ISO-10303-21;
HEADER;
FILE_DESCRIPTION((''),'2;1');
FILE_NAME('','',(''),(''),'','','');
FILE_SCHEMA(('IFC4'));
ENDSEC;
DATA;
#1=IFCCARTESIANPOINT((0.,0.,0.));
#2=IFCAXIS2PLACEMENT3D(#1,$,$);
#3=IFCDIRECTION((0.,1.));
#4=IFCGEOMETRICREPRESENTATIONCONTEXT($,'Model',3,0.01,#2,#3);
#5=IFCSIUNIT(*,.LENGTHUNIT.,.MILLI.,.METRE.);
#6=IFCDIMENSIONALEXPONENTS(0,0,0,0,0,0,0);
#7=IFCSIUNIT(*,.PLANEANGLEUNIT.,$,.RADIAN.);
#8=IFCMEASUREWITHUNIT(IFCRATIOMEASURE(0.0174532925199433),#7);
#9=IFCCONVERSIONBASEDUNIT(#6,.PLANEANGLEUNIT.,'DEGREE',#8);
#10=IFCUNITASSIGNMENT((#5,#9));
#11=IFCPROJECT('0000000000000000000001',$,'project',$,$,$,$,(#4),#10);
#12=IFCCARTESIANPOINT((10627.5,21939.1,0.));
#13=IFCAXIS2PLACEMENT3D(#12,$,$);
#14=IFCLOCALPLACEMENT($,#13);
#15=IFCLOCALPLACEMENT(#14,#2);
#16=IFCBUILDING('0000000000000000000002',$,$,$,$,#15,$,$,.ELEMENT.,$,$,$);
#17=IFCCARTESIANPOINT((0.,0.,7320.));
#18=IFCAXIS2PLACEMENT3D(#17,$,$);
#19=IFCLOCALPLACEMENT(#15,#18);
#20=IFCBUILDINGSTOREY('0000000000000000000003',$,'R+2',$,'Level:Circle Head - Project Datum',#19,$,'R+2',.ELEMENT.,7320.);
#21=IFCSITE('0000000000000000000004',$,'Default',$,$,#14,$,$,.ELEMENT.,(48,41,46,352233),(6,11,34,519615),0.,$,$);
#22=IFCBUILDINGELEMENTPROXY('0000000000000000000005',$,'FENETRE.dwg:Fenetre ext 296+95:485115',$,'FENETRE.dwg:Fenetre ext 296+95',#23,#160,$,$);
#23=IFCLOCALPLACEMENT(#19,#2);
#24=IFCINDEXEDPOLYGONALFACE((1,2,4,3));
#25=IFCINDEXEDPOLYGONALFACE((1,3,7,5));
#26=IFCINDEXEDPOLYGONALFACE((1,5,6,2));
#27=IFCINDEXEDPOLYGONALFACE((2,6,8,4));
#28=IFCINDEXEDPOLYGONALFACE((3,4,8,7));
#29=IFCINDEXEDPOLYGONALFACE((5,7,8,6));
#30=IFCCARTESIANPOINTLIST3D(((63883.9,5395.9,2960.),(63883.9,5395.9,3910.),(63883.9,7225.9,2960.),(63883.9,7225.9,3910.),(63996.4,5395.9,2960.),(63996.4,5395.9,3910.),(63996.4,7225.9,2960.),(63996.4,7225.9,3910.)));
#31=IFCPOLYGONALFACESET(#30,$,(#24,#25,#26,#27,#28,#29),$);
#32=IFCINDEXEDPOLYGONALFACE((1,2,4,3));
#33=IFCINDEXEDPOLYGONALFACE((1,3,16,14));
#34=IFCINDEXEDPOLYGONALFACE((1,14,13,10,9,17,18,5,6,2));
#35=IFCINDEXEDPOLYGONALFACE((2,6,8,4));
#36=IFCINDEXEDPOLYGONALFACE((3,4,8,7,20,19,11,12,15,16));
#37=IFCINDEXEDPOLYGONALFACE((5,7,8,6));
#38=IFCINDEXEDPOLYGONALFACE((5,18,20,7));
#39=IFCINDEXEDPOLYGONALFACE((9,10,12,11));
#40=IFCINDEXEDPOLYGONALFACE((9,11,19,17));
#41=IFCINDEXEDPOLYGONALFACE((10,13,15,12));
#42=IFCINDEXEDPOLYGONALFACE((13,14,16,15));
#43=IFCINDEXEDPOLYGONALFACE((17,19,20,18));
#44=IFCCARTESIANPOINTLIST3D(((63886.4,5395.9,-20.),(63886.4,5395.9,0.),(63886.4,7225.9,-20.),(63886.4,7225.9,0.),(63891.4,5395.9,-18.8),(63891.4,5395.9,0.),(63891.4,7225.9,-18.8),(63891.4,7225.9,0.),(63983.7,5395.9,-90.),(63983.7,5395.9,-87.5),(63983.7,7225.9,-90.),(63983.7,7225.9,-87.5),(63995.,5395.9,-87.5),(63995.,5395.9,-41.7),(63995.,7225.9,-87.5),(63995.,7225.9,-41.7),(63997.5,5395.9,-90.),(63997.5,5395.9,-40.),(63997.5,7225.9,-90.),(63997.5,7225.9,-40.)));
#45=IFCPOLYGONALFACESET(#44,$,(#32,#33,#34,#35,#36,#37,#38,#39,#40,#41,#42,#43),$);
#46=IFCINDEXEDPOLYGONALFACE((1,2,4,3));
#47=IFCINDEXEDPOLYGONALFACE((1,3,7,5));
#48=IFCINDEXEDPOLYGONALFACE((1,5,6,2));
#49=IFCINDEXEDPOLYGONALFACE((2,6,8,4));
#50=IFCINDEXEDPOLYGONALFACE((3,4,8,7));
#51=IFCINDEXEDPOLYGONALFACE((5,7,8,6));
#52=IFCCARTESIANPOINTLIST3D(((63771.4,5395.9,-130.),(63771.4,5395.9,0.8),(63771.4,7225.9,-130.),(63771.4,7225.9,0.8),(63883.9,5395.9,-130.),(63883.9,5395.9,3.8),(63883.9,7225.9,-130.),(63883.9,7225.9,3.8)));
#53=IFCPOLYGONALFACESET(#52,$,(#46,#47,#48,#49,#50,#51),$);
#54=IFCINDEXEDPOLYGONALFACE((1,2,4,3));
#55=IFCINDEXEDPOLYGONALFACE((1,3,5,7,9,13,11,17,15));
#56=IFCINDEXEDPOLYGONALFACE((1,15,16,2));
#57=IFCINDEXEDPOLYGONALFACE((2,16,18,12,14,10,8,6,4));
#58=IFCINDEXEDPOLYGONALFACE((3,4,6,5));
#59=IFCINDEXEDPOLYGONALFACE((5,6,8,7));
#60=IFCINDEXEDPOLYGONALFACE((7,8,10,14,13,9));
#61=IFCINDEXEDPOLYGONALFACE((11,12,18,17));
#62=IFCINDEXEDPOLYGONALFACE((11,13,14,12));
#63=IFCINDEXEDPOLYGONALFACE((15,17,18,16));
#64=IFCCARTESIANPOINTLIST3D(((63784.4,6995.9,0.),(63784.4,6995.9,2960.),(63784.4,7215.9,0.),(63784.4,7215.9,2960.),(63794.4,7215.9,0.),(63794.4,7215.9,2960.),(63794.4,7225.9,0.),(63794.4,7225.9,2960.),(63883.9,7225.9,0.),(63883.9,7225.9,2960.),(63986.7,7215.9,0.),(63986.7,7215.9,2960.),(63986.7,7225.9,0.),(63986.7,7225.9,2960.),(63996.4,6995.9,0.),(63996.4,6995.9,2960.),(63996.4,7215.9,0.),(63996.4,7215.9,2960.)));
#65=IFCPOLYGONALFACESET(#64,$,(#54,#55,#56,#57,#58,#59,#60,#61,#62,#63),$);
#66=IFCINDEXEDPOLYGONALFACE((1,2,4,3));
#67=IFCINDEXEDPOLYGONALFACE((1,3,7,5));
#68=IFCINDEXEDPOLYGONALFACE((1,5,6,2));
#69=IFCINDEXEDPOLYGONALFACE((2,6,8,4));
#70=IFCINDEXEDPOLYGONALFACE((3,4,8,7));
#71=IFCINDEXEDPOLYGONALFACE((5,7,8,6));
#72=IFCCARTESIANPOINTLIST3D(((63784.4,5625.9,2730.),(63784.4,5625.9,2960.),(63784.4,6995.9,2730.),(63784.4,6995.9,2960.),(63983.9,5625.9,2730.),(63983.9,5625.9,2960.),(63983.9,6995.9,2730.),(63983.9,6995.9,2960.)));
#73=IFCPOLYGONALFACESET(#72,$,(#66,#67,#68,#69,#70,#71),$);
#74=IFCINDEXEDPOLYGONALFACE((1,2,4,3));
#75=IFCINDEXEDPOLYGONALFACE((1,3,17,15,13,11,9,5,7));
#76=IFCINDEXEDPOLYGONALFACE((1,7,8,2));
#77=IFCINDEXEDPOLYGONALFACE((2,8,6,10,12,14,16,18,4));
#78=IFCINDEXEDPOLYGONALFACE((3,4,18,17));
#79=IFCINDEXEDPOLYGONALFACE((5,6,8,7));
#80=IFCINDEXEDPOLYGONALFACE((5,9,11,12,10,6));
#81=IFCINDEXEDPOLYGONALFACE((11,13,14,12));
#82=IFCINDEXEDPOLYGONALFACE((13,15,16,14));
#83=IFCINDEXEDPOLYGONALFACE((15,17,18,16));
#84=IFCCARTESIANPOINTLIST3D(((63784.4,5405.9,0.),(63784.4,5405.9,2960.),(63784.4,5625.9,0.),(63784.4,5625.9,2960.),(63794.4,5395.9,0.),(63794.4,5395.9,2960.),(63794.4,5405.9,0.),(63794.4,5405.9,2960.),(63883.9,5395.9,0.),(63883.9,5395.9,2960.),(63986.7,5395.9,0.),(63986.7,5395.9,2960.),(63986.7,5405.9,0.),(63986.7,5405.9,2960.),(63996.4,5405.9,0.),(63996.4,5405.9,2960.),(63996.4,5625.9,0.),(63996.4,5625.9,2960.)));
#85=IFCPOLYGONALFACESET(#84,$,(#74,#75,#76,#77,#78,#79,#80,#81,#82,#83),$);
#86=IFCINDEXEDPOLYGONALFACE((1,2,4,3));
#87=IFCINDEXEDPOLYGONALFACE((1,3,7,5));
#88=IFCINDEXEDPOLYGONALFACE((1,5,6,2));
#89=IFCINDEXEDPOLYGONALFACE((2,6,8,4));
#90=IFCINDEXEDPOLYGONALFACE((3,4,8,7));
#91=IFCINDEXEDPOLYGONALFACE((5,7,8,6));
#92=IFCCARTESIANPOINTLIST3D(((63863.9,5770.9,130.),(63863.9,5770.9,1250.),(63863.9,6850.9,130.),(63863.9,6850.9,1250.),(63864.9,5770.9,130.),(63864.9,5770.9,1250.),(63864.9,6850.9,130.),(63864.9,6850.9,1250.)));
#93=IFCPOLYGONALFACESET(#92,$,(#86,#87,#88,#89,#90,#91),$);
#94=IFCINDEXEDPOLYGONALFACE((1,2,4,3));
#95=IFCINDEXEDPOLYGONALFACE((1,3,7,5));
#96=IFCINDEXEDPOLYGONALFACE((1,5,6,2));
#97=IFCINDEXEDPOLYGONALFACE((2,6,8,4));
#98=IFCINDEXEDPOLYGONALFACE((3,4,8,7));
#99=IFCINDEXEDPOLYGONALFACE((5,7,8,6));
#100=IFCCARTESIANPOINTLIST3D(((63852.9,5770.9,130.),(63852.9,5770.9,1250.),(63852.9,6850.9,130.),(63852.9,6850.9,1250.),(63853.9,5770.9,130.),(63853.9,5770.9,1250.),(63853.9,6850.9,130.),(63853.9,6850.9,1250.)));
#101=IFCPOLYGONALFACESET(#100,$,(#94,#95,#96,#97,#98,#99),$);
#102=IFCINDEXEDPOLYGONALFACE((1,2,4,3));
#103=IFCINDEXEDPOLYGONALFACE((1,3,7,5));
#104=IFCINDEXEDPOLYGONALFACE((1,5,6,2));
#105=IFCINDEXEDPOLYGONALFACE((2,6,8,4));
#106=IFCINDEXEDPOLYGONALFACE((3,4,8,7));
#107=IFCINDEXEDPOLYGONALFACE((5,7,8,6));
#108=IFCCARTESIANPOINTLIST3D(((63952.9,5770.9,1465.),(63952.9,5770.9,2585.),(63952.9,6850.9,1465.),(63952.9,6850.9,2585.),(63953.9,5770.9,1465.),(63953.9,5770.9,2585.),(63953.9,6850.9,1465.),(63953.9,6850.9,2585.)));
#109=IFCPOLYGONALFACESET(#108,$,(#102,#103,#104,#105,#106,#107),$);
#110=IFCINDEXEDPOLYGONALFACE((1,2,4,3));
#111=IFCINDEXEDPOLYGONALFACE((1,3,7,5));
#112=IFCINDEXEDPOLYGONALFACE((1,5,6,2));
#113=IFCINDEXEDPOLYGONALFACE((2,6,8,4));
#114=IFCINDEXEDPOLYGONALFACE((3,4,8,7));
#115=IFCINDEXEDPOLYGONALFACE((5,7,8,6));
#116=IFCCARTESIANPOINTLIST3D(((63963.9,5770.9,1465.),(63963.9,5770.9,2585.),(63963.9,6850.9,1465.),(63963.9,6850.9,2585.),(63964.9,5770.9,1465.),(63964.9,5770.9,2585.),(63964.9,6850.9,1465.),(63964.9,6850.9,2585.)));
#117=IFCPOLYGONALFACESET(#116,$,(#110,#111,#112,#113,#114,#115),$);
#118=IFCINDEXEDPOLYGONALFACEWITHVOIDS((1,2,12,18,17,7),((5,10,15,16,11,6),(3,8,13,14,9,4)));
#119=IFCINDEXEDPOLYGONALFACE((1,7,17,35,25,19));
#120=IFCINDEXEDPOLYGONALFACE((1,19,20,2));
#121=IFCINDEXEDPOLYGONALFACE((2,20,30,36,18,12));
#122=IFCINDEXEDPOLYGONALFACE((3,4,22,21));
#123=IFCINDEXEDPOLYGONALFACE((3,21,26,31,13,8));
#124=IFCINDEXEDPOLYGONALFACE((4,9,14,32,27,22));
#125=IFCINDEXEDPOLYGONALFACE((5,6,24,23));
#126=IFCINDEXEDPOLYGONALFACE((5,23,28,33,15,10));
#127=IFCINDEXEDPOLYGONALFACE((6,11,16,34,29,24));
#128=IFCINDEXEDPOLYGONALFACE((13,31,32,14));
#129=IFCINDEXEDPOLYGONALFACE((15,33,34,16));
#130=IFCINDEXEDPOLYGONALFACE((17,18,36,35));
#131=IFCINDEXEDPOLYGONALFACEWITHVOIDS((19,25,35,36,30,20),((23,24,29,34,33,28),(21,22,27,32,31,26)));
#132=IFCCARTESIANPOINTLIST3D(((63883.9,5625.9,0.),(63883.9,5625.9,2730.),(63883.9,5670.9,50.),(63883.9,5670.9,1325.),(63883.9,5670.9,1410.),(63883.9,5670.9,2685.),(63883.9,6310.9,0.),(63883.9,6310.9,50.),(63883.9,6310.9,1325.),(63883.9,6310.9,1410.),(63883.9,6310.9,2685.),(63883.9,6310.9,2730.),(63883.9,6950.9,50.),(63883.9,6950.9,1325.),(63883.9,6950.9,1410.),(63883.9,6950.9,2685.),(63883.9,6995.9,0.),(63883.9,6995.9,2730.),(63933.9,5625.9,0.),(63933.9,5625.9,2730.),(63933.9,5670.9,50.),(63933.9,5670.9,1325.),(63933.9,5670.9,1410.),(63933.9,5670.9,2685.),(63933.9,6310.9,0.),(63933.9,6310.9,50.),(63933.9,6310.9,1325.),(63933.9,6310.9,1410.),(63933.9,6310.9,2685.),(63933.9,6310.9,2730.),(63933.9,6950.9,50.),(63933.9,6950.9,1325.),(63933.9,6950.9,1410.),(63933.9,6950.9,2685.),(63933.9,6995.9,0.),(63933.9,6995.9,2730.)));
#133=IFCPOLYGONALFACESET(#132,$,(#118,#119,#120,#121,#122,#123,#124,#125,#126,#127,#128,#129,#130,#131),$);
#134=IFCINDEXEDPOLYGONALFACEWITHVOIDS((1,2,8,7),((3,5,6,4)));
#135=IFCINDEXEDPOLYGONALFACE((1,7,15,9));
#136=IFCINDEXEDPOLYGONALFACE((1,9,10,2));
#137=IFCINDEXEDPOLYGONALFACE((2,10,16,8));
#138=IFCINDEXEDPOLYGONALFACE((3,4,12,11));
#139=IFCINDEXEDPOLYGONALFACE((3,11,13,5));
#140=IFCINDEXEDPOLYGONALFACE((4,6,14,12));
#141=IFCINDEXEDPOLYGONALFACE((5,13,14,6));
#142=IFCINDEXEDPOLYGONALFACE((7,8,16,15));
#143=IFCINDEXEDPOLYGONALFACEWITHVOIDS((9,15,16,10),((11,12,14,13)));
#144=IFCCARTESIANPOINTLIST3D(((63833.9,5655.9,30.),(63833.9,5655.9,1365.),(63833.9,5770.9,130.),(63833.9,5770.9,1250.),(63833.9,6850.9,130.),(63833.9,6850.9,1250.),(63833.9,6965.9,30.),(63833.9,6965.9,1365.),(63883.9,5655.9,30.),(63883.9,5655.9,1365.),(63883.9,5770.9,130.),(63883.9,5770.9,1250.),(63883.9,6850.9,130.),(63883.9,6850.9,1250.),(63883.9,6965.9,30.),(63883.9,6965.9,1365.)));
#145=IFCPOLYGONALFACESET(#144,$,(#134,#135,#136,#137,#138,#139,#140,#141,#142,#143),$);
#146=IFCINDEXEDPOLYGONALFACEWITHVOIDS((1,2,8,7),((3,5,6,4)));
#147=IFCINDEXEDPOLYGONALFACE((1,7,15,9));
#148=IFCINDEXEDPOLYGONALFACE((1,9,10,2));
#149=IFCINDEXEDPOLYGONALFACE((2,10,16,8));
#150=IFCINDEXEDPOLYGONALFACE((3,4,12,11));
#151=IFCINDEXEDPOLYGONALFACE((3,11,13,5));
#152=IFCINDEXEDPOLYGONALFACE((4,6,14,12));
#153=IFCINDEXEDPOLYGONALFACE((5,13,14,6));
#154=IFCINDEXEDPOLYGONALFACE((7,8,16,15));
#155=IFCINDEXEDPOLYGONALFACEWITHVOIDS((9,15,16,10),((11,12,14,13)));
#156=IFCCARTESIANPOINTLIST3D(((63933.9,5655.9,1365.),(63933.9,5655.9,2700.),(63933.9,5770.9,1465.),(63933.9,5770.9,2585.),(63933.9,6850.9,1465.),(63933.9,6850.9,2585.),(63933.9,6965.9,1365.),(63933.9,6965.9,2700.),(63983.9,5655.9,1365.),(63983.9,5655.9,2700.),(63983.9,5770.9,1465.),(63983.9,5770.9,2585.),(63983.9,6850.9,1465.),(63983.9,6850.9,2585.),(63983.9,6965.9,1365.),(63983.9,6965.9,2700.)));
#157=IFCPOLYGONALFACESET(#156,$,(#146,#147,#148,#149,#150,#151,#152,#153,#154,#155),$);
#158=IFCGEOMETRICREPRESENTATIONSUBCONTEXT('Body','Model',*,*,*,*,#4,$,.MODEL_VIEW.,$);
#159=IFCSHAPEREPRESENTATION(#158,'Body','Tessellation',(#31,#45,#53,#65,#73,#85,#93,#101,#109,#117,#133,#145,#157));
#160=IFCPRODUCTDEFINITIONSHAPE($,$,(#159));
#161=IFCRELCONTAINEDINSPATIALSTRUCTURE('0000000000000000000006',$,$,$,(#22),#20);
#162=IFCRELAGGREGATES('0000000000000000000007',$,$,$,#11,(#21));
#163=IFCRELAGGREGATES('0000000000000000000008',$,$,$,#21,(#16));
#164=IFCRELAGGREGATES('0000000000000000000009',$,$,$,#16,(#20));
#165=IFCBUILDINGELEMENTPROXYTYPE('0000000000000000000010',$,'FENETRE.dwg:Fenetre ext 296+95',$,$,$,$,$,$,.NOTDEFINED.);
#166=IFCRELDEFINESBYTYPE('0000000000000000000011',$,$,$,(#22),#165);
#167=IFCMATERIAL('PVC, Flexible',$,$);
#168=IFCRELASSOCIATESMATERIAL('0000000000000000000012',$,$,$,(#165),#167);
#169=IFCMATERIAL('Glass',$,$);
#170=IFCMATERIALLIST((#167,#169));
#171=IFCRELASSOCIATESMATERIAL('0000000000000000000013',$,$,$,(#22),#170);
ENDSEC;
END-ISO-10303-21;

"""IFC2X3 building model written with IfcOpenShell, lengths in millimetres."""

from ifc_helpers import new_model, entity, si_unit, converted_unit, direction, frame, frame_2d, origin, origin_2d_with_axis, place, context, subcontext, project, spatial, polyline, rectangle, outline, extrude, source, transform, mapped, material, material_list, type_object, type_shapes, element, save


model = new_model("IFC2X3")

# Units and contexts
model_context = context("Model", 3, precision=0.01, world=origin(), true_north=direction((0.0, 1.0)))
body_context = subcontext(model_context, "Body", "Model", "MODEL_VIEW")
ifc_project = project(units=[si_unit("LENGTHUNIT", "METRE", prefix="MILLI"), converted_unit("PLANEANGLEUNIT", "DEGREE", entity("IfcRatioMeasure", 0.0174532925199433), si_unit("PLANEANGLEUNIT", "RADIAN"), dimensions=[0, 0, 0, 0, 0, 0, 0])], contexts=[model_context])

# Site, building, storey
site_placement = place(None, frame((10627.5, 21939.1, 0.0)))
site = spatial("IfcSite", under=ifc_project, at=site_placement, Name="Default", CompositionType="ELEMENT", RefLatitude=(48, 41, 46, 352233), RefLongitude=(6, 11, 34, 519615), RefElevation=0.0)
building_placement = place(site_placement, origin())
building = spatial("IfcBuilding", under=site, at=building_placement, CompositionType="ELEMENT")
storey_placement = place(building_placement, frame((0.0, 0.0, 7320.0)))
storey = spatial("IfcBuildingStorey", under=building, at=storey_placement, Name="R+2", ObjectType="Level:Circle Head - Project Datum", LongName="R+2", CompositionType="ELEMENT", Elevation=7320.0)

# Building element proxy
ifc_material_1 = material(Name="PVC, Flexible")
ifc_material_2 = material(Name="Glass")
building_element_proxy_type_1 = type_object("IfcBuildingElementProxyType", Name="FENETRE.dwg:Fenetre ext 296+95", PredefinedType="NOTDEFINED", material=ifc_material_1)
shared_shape_1 = source(origin(), body_context, "Body", "SweptSolid", [
    extrude(rectangle(XDim=112.5, YDim=1830.0, at=origin_2d_with_axis()), frame((-10.4, -56.3, 2960.0), z_axis=(0.0, 0.0, 1.0), x_axis=(0.0, 1.0, 0.0)), (0.0, 0.0, 1.0), 950.0),
    extrude(outline(polyline([(27.5, -64.4), (47.5, -64.4), (47.5, -59.4), (28.8, -59.4), (7.5, 46.7), (-42.5, 46.7), (-42.5, 32.9), (-40.0, 32.9), (-40.0, 44.2), (5.8, 44.2), (27.5, -64.4)])), frame((-925.4, -66.9, -47.5), z_axis=(1.0, 0.0, 0.0), x_axis=(0.0, 0.0, 1.0)), (0.0, 0.0, 1.0), 1830.0),
    extrude(outline(polyline([(-54.5, -66.1), (58.0, -66.1), (54.5, 67.6), (-58.0, 64.6), (-54.5, -66.1)])), frame((-925.4, 56.3, -63.8), z_axis=(1.0, 0.0, 0.0), x_axis=(0.0, -0.999645, 0.02665)), (0.0, 0.0, 1.0), 1830.0),
    extrude(outline(polyline([(-97.0, -55.6), (5.9, -55.6), (95.4, -55.6), (95.4, -45.6), (105.4, -45.6), (105.4, 174.4), (-106.6, 174.4), (-106.6, -45.6), (-97.0, -45.6), (-97.0, -55.6)])), frame((849.0, -5.9, 0.0), z_axis=(0.0, 0.0, 1.0), x_axis=(0.0, 1.0, 0.0)), (0.0, 0.0, 1.0), 2960.0),
    extrude(rectangle(XDim=1370.0, YDim=199.5, at=origin_2d_with_axis()), frame((-10.4, -0.3, 2730.0), z_axis=(0.0, 0.0, 1.0), x_axis=(-1.0, 0.0, 0.0)), (0.0, 0.0, 1.0), 230.0),
    extrude(outline(polyline([(-55.6, 97.0), (-55.6, -5.9), (-55.6, -95.4), (-45.6, -95.4), (-45.6, -105.4), (174.4, -105.4), (174.4, 106.6), (-45.6, 106.6), (-45.6, 97.0), (-55.6, 97.0)])), frame((-869.9, -5.9, 0.0), z_axis=(0.0, 0.0, -1.0), x_axis=(1.0, 0.0, 0.0)), (0.0, 0.0, -1.0), 2960.0),
    extrude(rectangle(XDim=1080.0, YDim=1.0, at=origin_2d_with_axis()), frame((-10.4, 19.5, 130.0), z_axis=(0.0, 0.0, 1.0), x_axis=(-1.0, 0.0, 0.0)), (0.0, 0.0, 1.0), 1120.0),
    extrude(rectangle(XDim=1080.0, YDim=1.0, at=origin_2d_with_axis()), frame((-10.4, 30.5, 130.0), z_axis=(0.0, 0.0, 1.0), x_axis=(-1.0, 0.0, 0.0)), (0.0, 0.0, 1.0), 1120.0),
    extrude(rectangle(XDim=1080.0, YDim=1.0, at=frame_2d((0.0, 0.0), x_axis=(1.0, 0.0))), frame((-10.4, -69.5, 1465.0), z_axis=(0.0, 0.0, 1.0), x_axis=(-1.0, 0.0, 0.0)), (0.0, 0.0, 1.0), 1120.0),
    extrude(rectangle(XDim=1080.0, YDim=1.0, at=frame_2d((0.0, 0.0), x_axis=(1.0, 0.0))), frame((-10.4, -80.5, 1465.0), z_axis=(0.0, 0.0, 1.0), x_axis=(-1.0, 0.0, 0.0)), (0.0, 0.0, 1.0), 1120.0),
    extrude(outline(polyline([(-685.0, -1365.0), (0.0, -1365.0), (685.0, -1365.0), (685.0, 1365.0), (0.0, 1365.0), (-685.0, 1365.0), (-685.0, -1365.0)]), holes=[polyline([(-640.0, -1320.0), (-640.0, -45.0), (0.0, -45.0), (640.0, -45.0), (640.0, -1320.0), (0.0, -1320.0), (-640.0, -1320.0)]), polyline([(-640.0, 40.0), (-640.0, 1315.0), (0.0, 1315.0), (640.0, 1315.0), (640.0, 40.0), (0.0, 40.0), (-640.0, 40.0)])]), frame((-10.4, -50.0, 1365.0), z_axis=(0.0, 1.0, 0.0), x_axis=(1.0, 0.0, 0.0)), (0.0, 0.0, 1.0), 50.0),
    extrude(outline(polyline([(-655.0, -667.5), (655.0, -667.5), (655.0, 667.5), (-655.0, 667.5), (-655.0, -667.5)]), holes=[polyline([(-540.0, 552.5), (540.0, 552.5), (540.0, -567.5), (-540.0, -567.5), (-540.0, 552.5)])]), frame((-10.4, 0.0, 697.5), z_axis=(0.0, 1.0, 0.0), x_axis=(-1.0, 0.0, 0.0)), (0.0, 0.0, 1.0), 50.0),
    extrude(outline(polyline([(-655.0, -667.5), (655.0, -667.5), (655.0, 667.5), (-655.0, 667.5), (-655.0, -667.5)]), holes=[polyline([(-540.0, 552.5), (540.0, 552.5), (540.0, -567.5), (-540.0, -567.5), (-540.0, 552.5)])]), frame((-10.4, -100.0, 2032.5), z_axis=(0.0, 1.0, 0.0), x_axis=(-1.0, 0.0, 0.0)), (0.0, 0.0, 1.0), 50.0),
])
type_shapes(building_element_proxy_type_1, [shared_shape_1])
ifc_material_list_1 = material_list([ifc_material_1, ifc_material_2])
proxy_1_placement = place(storey_placement, frame((63883.9, 6321.3, 0.0), z_axis=(0.0, 0.0, 1.0), x_axis=(0.0, 1.0, 0.0)))
element("IfcBuildingElementProxy", 1, at=proxy_1_placement, inside=storey, type_object=building_element_proxy_type_1, material=ifc_material_list_1, Name="FENETRE.dwg:Fenetre ext 296+95:485115", ObjectType="FENETRE.dwg:Fenetre ext 296+95", context=body_context, shape_type="MappedRepresentation", body=[
    mapped(shared_shape_1, transform((0.0, 0.0, 0.0), scale=1.0)),
])

save(model, "model.ifc")
